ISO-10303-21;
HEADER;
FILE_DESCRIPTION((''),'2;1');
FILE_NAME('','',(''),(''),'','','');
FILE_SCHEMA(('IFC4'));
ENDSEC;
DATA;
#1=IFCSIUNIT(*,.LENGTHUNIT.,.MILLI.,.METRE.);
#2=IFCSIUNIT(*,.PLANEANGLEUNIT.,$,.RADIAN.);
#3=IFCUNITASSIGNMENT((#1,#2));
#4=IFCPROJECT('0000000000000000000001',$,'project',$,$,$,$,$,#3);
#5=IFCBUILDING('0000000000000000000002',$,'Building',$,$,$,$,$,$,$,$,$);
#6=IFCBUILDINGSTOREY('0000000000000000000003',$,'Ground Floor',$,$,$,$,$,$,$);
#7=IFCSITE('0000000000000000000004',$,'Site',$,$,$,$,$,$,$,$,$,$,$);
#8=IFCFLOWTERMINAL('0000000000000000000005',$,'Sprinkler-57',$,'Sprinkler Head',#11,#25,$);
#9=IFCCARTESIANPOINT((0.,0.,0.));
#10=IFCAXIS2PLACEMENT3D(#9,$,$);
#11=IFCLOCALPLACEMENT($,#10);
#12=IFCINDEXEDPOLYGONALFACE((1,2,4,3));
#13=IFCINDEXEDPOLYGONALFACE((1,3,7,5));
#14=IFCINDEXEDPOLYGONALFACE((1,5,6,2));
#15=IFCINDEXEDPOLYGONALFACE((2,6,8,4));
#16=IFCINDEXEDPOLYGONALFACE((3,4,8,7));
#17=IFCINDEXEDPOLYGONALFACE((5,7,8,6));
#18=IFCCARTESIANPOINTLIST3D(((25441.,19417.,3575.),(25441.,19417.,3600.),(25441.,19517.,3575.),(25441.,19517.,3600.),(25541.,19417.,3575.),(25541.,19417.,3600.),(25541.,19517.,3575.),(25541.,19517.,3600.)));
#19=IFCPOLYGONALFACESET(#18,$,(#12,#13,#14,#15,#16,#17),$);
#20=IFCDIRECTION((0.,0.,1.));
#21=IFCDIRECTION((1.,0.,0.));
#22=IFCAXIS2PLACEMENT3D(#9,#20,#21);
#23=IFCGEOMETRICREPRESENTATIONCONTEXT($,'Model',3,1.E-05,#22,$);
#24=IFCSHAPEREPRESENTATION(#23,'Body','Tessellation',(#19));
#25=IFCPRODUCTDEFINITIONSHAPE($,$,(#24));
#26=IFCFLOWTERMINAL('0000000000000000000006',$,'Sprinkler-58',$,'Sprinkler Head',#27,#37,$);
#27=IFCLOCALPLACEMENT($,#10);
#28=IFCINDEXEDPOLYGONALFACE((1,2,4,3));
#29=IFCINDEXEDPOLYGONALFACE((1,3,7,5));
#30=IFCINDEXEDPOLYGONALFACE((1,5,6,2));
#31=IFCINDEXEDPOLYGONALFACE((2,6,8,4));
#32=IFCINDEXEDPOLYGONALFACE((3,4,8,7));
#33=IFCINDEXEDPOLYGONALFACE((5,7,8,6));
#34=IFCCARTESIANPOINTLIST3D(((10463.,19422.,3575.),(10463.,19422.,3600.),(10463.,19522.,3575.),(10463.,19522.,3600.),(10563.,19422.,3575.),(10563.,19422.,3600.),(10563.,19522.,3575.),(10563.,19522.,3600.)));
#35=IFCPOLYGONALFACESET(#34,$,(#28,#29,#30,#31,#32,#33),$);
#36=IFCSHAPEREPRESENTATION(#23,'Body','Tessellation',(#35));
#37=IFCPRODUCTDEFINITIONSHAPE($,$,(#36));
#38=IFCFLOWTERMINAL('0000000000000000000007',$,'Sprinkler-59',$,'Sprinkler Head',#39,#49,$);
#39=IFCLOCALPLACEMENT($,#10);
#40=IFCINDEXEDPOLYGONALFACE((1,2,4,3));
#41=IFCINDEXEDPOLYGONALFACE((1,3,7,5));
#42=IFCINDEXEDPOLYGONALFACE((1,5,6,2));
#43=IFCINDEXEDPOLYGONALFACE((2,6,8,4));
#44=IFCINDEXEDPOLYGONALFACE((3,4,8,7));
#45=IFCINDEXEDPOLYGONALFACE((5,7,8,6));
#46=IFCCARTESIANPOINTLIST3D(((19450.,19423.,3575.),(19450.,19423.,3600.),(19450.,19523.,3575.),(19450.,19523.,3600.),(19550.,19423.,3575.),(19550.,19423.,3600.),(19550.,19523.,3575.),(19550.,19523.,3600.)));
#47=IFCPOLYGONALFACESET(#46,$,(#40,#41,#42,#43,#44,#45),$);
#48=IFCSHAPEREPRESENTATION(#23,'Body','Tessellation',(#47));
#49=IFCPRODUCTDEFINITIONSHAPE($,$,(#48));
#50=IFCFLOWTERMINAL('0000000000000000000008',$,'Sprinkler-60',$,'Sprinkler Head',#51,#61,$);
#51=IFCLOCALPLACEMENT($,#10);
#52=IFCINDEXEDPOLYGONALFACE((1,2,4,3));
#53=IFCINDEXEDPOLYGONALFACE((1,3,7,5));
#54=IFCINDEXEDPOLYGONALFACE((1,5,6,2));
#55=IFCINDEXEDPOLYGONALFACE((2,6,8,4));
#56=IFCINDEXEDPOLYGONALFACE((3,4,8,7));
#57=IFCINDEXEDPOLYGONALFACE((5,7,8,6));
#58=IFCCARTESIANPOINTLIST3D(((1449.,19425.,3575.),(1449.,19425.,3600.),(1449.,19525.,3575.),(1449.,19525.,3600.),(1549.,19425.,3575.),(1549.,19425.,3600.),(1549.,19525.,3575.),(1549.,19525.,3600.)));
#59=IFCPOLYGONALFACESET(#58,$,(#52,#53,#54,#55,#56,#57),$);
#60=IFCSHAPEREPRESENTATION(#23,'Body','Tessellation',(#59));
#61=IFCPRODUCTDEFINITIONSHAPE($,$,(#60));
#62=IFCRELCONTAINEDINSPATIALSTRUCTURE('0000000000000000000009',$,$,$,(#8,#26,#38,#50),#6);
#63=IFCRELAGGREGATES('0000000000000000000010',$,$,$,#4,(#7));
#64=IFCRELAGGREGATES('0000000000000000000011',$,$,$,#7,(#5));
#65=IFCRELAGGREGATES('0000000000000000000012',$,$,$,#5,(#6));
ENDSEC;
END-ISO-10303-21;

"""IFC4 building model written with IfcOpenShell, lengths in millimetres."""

from ifc_helpers import new_model, si_unit, frame, origin_with_axes, place, context, project, spatial, rectangle, extrude, element, save


model = new_model("IFC4")

# Units and contexts
model_context = context("Model", 3, precision=1e-05, world=origin_with_axes())
ifc_project = project(units=[si_unit("LENGTHUNIT", "METRE", prefix="MILLI"), si_unit("PLANEANGLEUNIT", "RADIAN")])

# Site, building, storey
site = spatial("IfcSite", under=ifc_project, Name="Site")
building = spatial("IfcBuilding", under=site, Name="Building")
storey = spatial("IfcBuildingStorey", under=building, Name="Ground Floor")

# Flow terminals
flow_terminal_1_placement = place(None, origin_with_axes())
element("IfcFlowTerminal", 1, at=flow_terminal_1_placement, inside=storey, Name="Sprinkler-57", ObjectType="Sprinkler Head", context=model_context, shape_type="SweptSolid", body=[
    extrude(rectangle(XDim=100.0, YDim=100.0), frame((25491.0, 19467.0, 3575.0), z_axis=(0.0, 0.0, 1.0), x_axis=(1.0, 0.0, 0.0)), (0.0, 0.0, 1.0), 25.0),
])
flow_terminal_2_placement = place(None, origin_with_axes())
element("IfcFlowTerminal", 2, at=flow_terminal_2_placement, inside=storey, Name="Sprinkler-58", ObjectType="Sprinkler Head", context=model_context, shape_type="SweptSolid", body=[
    extrude(rectangle(XDim=100.0, YDim=100.0), frame((10513.0, 19472.0, 3575.0), z_axis=(0.0, 0.0, 1.0), x_axis=(1.0, 0.0, 0.0)), (0.0, 0.0, 1.0), 25.0),
])
flow_terminal_3_placement = place(None, origin_with_axes())
element("IfcFlowTerminal", 3, at=flow_terminal_3_placement, inside=storey, Name="Sprinkler-59", ObjectType="Sprinkler Head", context=model_context, shape_type="SweptSolid", body=[
    extrude(rectangle(XDim=100.0, YDim=100.0), frame((19500.0, 19473.0, 3575.0), z_axis=(0.0, 0.0, 1.0), x_axis=(1.0, 0.0, 0.0)), (0.0, 0.0, 1.0), 25.0),
])
flow_terminal_4_placement = place(None, origin_with_axes())
element("IfcFlowTerminal", 4, at=flow_terminal_4_placement, inside=storey, Name="Sprinkler-60", ObjectType="Sprinkler Head", context=model_context, shape_type="SweptSolid", body=[
    extrude(rectangle(XDim=100.0, YDim=100.0), frame((1499.0, 19475.0, 3575.0), z_axis=(0.0, 0.0, 1.0), x_axis=(1.0, 0.0, 0.0)), (0.0, 0.0, 1.0), 25.0),
])

save(model, "model.ifc")
